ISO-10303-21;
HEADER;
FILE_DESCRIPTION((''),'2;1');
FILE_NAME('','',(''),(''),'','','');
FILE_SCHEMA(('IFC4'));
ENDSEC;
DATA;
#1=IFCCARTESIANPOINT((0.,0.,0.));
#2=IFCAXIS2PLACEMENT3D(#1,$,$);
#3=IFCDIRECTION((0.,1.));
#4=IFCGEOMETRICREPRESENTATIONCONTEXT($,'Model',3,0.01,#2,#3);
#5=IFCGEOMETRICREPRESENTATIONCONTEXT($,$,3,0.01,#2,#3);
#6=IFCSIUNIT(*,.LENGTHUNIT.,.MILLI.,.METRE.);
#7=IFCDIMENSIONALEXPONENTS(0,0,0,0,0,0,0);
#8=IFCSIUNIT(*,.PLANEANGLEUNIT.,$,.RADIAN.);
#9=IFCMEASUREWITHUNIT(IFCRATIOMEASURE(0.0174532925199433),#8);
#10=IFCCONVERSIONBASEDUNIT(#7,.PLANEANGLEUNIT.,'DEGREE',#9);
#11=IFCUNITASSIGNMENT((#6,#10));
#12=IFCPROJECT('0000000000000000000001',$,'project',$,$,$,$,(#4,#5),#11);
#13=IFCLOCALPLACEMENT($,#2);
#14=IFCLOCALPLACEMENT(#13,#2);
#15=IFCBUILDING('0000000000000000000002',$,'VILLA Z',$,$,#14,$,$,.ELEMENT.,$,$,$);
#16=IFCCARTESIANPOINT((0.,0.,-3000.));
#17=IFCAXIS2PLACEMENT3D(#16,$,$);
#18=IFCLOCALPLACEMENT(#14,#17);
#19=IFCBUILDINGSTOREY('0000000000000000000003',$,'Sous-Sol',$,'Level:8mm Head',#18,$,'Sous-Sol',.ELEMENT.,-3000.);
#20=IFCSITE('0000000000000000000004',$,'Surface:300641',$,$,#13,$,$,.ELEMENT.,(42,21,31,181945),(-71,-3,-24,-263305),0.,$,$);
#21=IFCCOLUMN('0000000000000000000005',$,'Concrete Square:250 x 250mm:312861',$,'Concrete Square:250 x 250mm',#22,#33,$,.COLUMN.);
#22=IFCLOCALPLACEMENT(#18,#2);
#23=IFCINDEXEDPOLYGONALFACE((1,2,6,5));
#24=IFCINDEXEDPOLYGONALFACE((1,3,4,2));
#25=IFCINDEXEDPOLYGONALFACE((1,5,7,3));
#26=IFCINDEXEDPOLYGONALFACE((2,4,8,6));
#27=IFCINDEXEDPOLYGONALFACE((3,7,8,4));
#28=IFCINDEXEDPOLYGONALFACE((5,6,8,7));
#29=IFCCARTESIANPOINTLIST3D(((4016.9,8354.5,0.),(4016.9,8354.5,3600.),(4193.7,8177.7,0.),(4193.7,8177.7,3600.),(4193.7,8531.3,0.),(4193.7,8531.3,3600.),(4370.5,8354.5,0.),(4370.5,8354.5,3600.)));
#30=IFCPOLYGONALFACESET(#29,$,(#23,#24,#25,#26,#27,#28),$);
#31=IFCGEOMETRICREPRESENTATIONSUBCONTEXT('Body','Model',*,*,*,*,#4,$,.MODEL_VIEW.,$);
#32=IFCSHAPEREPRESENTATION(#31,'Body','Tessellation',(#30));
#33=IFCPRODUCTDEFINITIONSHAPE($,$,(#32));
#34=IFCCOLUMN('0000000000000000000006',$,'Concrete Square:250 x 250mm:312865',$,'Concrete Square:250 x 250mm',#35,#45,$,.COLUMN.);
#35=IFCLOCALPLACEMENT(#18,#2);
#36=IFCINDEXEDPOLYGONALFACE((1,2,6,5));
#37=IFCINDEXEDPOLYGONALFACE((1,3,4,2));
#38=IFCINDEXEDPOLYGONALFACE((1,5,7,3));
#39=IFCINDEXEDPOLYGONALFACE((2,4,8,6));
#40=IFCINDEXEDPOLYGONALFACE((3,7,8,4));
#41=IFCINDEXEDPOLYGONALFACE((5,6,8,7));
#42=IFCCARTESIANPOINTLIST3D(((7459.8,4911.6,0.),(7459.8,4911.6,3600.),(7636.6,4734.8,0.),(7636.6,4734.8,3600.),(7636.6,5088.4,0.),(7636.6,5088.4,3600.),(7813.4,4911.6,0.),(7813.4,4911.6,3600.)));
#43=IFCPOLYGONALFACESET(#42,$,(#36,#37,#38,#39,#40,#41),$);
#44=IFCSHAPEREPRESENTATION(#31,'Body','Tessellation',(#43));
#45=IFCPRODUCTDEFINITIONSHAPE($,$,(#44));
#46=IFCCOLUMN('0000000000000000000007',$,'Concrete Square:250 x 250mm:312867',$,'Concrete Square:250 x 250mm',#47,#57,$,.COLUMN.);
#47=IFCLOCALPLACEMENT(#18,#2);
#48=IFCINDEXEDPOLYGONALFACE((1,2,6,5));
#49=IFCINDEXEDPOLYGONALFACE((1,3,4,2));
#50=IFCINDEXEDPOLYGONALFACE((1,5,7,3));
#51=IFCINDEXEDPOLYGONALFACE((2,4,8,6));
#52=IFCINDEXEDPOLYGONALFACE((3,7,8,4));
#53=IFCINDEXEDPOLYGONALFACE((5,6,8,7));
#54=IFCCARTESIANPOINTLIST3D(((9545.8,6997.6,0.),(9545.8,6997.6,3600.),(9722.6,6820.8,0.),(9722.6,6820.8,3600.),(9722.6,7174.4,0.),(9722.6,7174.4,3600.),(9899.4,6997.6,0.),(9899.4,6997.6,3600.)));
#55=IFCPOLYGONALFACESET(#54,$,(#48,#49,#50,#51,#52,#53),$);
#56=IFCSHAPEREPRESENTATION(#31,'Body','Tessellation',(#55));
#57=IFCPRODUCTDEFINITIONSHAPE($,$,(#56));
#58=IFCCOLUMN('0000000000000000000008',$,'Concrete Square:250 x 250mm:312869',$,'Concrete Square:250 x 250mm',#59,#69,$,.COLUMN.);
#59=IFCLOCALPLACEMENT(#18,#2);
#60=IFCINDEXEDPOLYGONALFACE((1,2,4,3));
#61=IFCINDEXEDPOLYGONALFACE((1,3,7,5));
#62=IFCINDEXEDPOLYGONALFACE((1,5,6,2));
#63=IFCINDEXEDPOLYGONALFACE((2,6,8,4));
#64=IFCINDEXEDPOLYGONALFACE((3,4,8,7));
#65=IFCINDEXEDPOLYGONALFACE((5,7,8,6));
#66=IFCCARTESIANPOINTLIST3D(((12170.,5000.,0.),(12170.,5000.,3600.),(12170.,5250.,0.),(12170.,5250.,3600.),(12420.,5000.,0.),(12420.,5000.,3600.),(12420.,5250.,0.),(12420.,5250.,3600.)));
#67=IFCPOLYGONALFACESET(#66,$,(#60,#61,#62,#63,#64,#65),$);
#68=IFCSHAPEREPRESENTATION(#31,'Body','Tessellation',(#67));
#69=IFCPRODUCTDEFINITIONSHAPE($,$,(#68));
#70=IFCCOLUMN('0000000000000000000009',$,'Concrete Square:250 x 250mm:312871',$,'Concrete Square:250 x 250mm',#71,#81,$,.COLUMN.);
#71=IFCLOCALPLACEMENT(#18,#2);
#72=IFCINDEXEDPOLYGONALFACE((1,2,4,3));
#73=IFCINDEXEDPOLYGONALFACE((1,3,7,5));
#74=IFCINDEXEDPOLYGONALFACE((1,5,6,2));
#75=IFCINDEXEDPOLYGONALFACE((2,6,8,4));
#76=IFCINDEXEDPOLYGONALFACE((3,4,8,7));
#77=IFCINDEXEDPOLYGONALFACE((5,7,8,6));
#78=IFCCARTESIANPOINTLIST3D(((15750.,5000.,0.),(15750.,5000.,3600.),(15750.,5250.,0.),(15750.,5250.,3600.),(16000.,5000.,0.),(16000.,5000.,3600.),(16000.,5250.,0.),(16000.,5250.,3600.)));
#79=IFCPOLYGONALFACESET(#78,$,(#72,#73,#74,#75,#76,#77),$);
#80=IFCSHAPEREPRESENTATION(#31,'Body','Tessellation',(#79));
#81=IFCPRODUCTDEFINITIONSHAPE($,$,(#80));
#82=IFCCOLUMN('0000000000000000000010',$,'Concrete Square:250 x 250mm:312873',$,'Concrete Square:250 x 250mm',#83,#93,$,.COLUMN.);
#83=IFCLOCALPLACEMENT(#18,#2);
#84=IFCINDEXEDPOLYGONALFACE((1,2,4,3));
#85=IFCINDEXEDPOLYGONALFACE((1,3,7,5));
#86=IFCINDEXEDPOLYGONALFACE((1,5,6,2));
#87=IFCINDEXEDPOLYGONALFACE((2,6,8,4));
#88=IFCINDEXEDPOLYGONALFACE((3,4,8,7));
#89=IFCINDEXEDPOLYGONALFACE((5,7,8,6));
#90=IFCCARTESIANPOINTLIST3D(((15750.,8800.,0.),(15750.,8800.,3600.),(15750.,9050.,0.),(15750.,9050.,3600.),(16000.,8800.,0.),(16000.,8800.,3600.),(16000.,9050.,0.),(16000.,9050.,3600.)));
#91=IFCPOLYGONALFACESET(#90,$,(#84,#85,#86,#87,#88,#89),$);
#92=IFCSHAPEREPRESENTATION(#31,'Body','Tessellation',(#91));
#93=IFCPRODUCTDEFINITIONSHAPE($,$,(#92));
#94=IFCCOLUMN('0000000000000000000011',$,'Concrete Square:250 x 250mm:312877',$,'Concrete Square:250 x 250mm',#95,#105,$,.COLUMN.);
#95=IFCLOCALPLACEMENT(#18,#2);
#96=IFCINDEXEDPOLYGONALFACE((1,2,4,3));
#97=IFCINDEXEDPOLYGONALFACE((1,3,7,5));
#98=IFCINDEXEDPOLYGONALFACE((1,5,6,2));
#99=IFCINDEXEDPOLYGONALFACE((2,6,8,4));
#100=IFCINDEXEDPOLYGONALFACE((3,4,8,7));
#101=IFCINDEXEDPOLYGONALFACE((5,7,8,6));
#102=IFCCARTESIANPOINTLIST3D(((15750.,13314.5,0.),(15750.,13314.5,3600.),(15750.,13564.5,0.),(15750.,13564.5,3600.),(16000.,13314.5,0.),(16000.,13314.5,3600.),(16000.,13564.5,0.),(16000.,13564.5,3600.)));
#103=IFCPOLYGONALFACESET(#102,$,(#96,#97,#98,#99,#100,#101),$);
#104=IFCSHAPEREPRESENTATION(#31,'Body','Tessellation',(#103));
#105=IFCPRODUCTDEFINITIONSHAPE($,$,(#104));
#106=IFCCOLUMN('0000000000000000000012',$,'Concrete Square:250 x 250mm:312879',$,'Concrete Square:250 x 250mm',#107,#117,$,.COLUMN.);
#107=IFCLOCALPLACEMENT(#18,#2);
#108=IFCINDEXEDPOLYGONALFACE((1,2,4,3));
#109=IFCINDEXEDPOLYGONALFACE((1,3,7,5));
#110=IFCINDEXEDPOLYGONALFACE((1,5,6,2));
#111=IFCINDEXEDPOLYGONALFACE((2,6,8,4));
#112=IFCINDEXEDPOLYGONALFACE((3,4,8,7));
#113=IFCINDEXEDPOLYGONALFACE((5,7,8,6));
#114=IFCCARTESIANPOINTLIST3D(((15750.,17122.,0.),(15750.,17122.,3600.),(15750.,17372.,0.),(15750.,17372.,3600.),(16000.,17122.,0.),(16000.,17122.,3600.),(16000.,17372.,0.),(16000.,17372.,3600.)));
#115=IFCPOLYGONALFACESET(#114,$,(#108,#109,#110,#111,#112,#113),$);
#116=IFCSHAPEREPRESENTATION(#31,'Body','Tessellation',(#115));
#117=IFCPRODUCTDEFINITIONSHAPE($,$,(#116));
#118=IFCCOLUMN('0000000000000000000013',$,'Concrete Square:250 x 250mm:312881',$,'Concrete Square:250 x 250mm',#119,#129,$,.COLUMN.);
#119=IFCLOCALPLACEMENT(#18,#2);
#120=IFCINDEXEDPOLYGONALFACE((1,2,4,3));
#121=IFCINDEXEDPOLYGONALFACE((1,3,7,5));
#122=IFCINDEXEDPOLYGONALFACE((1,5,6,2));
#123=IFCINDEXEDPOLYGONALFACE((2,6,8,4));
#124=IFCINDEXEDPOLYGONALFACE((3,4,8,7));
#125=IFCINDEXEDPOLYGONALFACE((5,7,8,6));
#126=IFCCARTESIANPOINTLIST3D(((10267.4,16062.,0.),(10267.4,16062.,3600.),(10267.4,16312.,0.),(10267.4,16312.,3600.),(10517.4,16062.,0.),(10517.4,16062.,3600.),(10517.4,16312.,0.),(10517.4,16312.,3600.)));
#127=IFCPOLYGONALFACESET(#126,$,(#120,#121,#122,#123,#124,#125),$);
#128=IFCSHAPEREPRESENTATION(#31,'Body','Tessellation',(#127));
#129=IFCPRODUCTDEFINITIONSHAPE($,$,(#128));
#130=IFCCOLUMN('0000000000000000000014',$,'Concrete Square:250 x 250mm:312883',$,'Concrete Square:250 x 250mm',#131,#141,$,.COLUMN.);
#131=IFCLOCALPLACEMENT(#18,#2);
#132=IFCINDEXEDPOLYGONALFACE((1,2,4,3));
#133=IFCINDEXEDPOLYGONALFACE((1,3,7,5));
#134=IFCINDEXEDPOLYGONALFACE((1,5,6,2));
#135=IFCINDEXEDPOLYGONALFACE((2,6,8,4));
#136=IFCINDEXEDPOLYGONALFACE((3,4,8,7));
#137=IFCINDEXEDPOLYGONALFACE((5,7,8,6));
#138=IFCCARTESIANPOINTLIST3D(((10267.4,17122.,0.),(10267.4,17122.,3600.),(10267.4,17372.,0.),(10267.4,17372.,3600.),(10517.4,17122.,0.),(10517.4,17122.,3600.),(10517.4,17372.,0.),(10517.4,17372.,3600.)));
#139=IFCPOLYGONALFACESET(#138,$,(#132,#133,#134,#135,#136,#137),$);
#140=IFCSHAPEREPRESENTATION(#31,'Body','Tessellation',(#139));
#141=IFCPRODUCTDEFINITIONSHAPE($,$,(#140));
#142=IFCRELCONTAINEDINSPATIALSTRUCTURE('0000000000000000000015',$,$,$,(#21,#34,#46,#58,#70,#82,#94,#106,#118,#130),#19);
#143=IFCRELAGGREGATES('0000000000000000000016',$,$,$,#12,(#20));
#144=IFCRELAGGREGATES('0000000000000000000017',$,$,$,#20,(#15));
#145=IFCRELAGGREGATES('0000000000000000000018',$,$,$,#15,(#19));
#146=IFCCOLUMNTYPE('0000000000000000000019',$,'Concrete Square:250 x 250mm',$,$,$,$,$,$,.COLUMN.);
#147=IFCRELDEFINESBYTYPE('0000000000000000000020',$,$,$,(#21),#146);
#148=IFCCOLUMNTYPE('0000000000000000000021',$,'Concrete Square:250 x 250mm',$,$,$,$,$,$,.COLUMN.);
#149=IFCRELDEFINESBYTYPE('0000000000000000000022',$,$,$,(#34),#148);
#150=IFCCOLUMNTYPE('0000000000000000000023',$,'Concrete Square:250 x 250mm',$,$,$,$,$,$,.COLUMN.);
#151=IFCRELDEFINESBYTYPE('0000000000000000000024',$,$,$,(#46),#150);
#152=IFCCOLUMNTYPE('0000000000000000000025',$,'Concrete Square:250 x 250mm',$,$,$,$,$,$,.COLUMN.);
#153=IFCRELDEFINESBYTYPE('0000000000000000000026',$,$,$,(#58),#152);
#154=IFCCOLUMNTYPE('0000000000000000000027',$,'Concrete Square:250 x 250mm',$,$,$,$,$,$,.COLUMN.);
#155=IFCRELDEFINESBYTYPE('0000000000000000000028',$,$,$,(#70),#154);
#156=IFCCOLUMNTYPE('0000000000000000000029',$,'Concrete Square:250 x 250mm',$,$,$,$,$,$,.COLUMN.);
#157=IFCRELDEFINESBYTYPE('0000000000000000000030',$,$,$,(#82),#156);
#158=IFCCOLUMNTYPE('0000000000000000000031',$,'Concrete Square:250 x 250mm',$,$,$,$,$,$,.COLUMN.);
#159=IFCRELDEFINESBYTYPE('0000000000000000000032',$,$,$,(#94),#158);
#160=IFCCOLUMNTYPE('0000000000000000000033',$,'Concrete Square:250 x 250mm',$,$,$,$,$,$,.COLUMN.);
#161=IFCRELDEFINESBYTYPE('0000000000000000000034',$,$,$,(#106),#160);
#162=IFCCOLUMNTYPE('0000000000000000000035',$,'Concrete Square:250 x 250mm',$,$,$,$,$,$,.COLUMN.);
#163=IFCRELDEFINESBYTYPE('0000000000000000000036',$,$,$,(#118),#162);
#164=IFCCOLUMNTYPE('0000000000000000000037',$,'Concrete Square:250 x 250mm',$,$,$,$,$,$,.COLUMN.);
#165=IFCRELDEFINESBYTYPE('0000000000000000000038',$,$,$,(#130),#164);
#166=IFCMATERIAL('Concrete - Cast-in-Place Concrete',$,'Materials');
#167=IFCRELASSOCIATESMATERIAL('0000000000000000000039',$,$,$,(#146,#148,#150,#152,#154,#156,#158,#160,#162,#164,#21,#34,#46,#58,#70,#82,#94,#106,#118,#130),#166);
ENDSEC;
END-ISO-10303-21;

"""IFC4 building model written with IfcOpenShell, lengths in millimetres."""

from ifc_helpers import new_model, entity, si_unit, converted_unit, direction, frame, frame_2d, origin, origin_2d_with_axis, place, context, subcontext, project, spatial, rectangle, extrude, source, transform, mapped, material, material_profile, profile_set, profile_usage, type_object, type_shapes, element, save


model = new_model("IFC4")

# Units and contexts
model_context = context("Model", 3, precision=0.01, world=origin(), true_north=direction((0.0, 1.0)))
context_of_model = context(None, 3, precision=0.01, world=origin(), true_north=direction((0.0, 1.0)))
body_context = subcontext(model_context, "Body", "Model", "MODEL_VIEW")
ifc_project = project(units=[si_unit("LENGTHUNIT", "METRE", prefix="MILLI"), converted_unit("PLANEANGLEUNIT", "DEGREE", entity("IfcRatioMeasure", 0.0174532925199433), si_unit("PLANEANGLEUNIT", "RADIAN"), dimensions=[0, 0, 0, 0, 0, 0, 0])], contexts=[model_context, context_of_model])

# Site, building, storey
site_placement = place(None, origin())
site = spatial("IfcSite", under=ifc_project, at=site_placement, Name="Surface:300641", CompositionType="ELEMENT", RefLatitude=(42, 21, 31, 181945), RefLongitude=(-71, -3, -24, -263305), RefElevation=0.0)
building_placement = place(site_placement, origin())
building = spatial("IfcBuilding", under=site, at=building_placement, Name="VILLA Z", CompositionType="ELEMENT")
storey_placement = place(building_placement, frame((0.0, 0.0, -3000.0)))
storey = spatial("IfcBuildingStorey", under=building, at=storey_placement, Name="Sous-Sol", ObjectType="Level:8mm Head", LongName="Sous-Sol", CompositionType="ELEMENT", Elevation=-3000.0)

# Columns
ifc_material_1 = material(Name="Concrete - Cast-in-Place Concrete", Category="Materials")
ifc_material_profile = material_profile(ifc_material_1, rectangle(XDim=250.0, YDim=250.0, at=frame_2d((0.0, 0.0), x_axis=(1.0, 0.0))), Name="250 x 250mm")
ifc_profile_set = profile_set([ifc_material_profile], Name="250 x 250mm")
ifc_profile_usage_1 = profile_usage(ifc_profile_set)
column_type_1 = type_object("IfcColumnType", Name="Concrete Square:250 x 250mm", PredefinedType="COLUMN", material=ifc_profile_set)
shared_shape_1 = source(origin(), body_context, "Body", "SweptSolid", [
    extrude(rectangle(XDim=250.0, YDim=250.0, at=frame_2d((0.0, 0.0), x_axis=(1.0, 0.0))), frame((4193.7, 8354.5, -3000.0), z_axis=(0.0, 0.0, 1.0), x_axis=(-0.707107, 0.707107, 0.0)), (0.0, 0.0, 1.0), 3600.0),
])
type_shapes(column_type_1, [shared_shape_1])
column_1_placement = place(storey_placement, frame((0.0, 0.0, 3000.0)))
element("IfcColumn", 1, at=column_1_placement, inside=storey, type_object=column_type_1, material=ifc_profile_usage_1, Name="Concrete Square:250 x 250mm:312861", ObjectType="Concrete Square:250 x 250mm", PredefinedType="COLUMN", context=body_context, shape_type="MappedRepresentation", body=[
    mapped(shared_shape_1, transform((0.0, 0.0, 0.0), scale=1.0)),
])
ifc_profile_usage_2 = profile_usage(ifc_profile_set)
column_type_2 = type_object("IfcColumnType", Name="Concrete Square:250 x 250mm", PredefinedType="COLUMN", material=ifc_profile_set)
shared_shape_2 = source(origin(), body_context, "Body", "SweptSolid", [
    extrude(rectangle(XDim=250.0, YDim=250.0, at=frame_2d((0.0, 0.0), x_axis=(1.0, 0.0))), frame((7636.6, 4911.6, -3000.0), z_axis=(0.0, 0.0, 1.0), x_axis=(-0.707107, 0.707107, 0.0)), (0.0, 0.0, 1.0), 3600.0),
])
type_shapes(column_type_2, [shared_shape_2])
column_2_placement = place(storey_placement, frame((0.0, 0.0, 3000.0)))
element("IfcColumn", 2, at=column_2_placement, inside=storey, type_object=column_type_2, material=ifc_profile_usage_2, Name="Concrete Square:250 x 250mm:312865", ObjectType="Concrete Square:250 x 250mm", PredefinedType="COLUMN", context=body_context, shape_type="MappedRepresentation", body=[
    mapped(shared_shape_2, transform((0.0, 0.0, 0.0), scale=1.0)),
])
ifc_profile_usage_3 = profile_usage(ifc_profile_set)
column_type_3 = type_object("IfcColumnType", Name="Concrete Square:250 x 250mm", PredefinedType="COLUMN", material=ifc_profile_set)
shared_shape_3 = source(origin(), body_context, "Body", "SweptSolid", [
    extrude(rectangle(XDim=250.0, YDim=250.0, at=origin_2d_with_axis()), frame((9722.6, 6997.6, -3000.0), z_axis=(0.0, 0.0, 1.0), x_axis=(-0.707107, 0.707107, 0.0)), (0.0, 0.0, 1.0), 3600.0),
])
type_shapes(column_type_3, [shared_shape_3])
column_3_placement = place(storey_placement, frame((0.0, 0.0, 3000.0)))
element("IfcColumn", 3, at=column_3_placement, inside=storey, type_object=column_type_3, material=ifc_profile_usage_3, Name="Concrete Square:250 x 250mm:312867", ObjectType="Concrete Square:250 x 250mm", PredefinedType="COLUMN", context=body_context, shape_type="MappedRepresentation", body=[
    mapped(shared_shape_3, transform((0.0, 0.0, 0.0), scale=1.0)),
])
ifc_profile_usage_4 = profile_usage(ifc_profile_set)
column_type_4 = type_object("IfcColumnType", Name="Concrete Square:250 x 250mm", PredefinedType="COLUMN", material=ifc_profile_set)
shared_shape_4 = source(origin(), body_context, "Body", "SweptSolid", [
    extrude(rectangle(XDim=250.0, YDim=250.0, at=origin_2d_with_axis()), frame((12295.0, 5125.0, -3000.0), z_axis=(0.0, 0.0, 1.0), x_axis=(0.0, -1.0, 0.0)), (0.0, 0.0, 1.0), 3600.0),
])
type_shapes(column_type_4, [shared_shape_4])
column_4_placement = place(storey_placement, frame((0.0, 0.0, 3000.0)))
element("IfcColumn", 4, at=column_4_placement, inside=storey, type_object=column_type_4, material=ifc_profile_usage_4, Name="Concrete Square:250 x 250mm:312869", ObjectType="Concrete Square:250 x 250mm", PredefinedType="COLUMN", context=body_context, shape_type="MappedRepresentation", body=[
    mapped(shared_shape_4, transform((0.0, 0.0, 0.0), scale=1.0)),
])
ifc_profile_usage_5 = profile_usage(ifc_profile_set)
column_type_5 = type_object("IfcColumnType", Name="Concrete Square:250 x 250mm", PredefinedType="COLUMN", material=ifc_profile_set)
shared_shape_5 = source(origin(), body_context, "Body", "SweptSolid", [
    extrude(rectangle(XDim=250.0, YDim=250.0, at=origin_2d_with_axis()), frame((15875.0, 5125.0, -3000.0), z_axis=(0.0, 0.0, 1.0), x_axis=(0.0, -1.0, 0.0)), (0.0, 0.0, 1.0), 3600.0),
])
type_shapes(column_type_5, [shared_shape_5])
column_5_placement = place(storey_placement, frame((0.0, 0.0, 3000.0)))
element("IfcColumn", 5, at=column_5_placement, inside=storey, type_object=column_type_5, material=ifc_profile_usage_5, Name="Concrete Square:250 x 250mm:312871", ObjectType="Concrete Square:250 x 250mm", PredefinedType="COLUMN", context=body_context, shape_type="MappedRepresentation", body=[
    mapped(shared_shape_5, transform((0.0, 0.0, 0.0), scale=1.0)),
])
ifc_profile_usage_6 = profile_usage(ifc_profile_set)
column_type_6 = type_object("IfcColumnType", Name="Concrete Square:250 x 250mm", PredefinedType="COLUMN", material=ifc_profile_set)
shared_shape_6 = source(origin(), body_context, "Body", "SweptSolid", [
    extrude(rectangle(XDim=250.0, YDim=250.0, at=origin_2d_with_axis()), frame((15875.0, 8925.0, -3000.0), z_axis=(0.0, 0.0, 1.0), x_axis=(0.0, -1.0, 0.0)), (0.0, 0.0, 1.0), 3600.0),
])
type_shapes(column_type_6, [shared_shape_6])
column_6_placement = place(storey_placement, frame((0.0, 0.0, 3000.0)))
element("IfcColumn", 6, at=column_6_placement, inside=storey, type_object=column_type_6, material=ifc_profile_usage_6, Name="Concrete Square:250 x 250mm:312873", ObjectType="Concrete Square:250 x 250mm", PredefinedType="COLUMN", context=body_context, shape_type="MappedRepresentation", body=[
    mapped(shared_shape_6, transform((0.0, 0.0, 0.0), scale=1.0)),
])
ifc_profile_usage_7 = profile_usage(ifc_profile_set)
column_type_7 = type_object("IfcColumnType", Name="Concrete Square:250 x 250mm", PredefinedType="COLUMN", material=ifc_profile_set)
shared_shape_7 = source(origin(), body_context, "Body", "SweptSolid", [
    extrude(rectangle(XDim=250.0, YDim=250.0, at=frame_2d((0.0, 0.0), x_axis=(1.0, 0.0))), frame((15875.0, 13439.5, -3000.0), z_axis=(0.0, 0.0, 1.0), x_axis=(0.0, -1.0, 0.0)), (0.0, 0.0, 1.0), 3600.0),
])
type_shapes(column_type_7, [shared_shape_7])
column_7_placement = place(storey_placement, frame((0.0, 0.0, 3000.0)))
element("IfcColumn", 7, at=column_7_placement, inside=storey, type_object=column_type_7, material=ifc_profile_usage_7, Name="Concrete Square:250 x 250mm:312877", ObjectType="Concrete Square:250 x 250mm", PredefinedType="COLUMN", context=body_context, shape_type="MappedRepresentation", body=[
    mapped(shared_shape_7, transform((0.0, 0.0, 0.0), scale=1.0)),
])
ifc_profile_usage_8 = profile_usage(ifc_profile_set)
column_type_8 = type_object("IfcColumnType", Name="Concrete Square:250 x 250mm", PredefinedType="COLUMN", material=ifc_profile_set)
shared_shape_8 = source(origin(), body_context, "Body", "SweptSolid", [
    extrude(rectangle(XDim=250.0, YDim=250.0, at=origin_2d_with_axis()), frame((15875.0, 17247.0, -3000.0), z_axis=(0.0, 0.0, 1.0), x_axis=(0.0, -1.0, 0.0)), (0.0, 0.0, 1.0), 3600.0),
])
type_shapes(column_type_8, [shared_shape_8])
column_8_placement = place(storey_placement, frame((0.0, 0.0, 3000.0)))
element("IfcColumn", 8, at=column_8_placement, inside=storey, type_object=column_type_8, material=ifc_profile_usage_8, Name="Concrete Square:250 x 250mm:312879", ObjectType="Concrete Square:250 x 250mm", PredefinedType="COLUMN", context=body_context, shape_type="MappedRepresentation", body=[
    mapped(shared_shape_8, transform((0.0, 0.0, 0.0), scale=1.0)),
])
ifc_profile_usage_9 = profile_usage(ifc_profile_set)
column_type_9 = type_object("IfcColumnType", Name="Concrete Square:250 x 250mm", PredefinedType="COLUMN", material=ifc_profile_set)
shared_shape_9 = source(origin(), body_context, "Body", "SweptSolid", [
    extrude(rectangle(XDim=250.0, YDim=250.0, at=frame_2d((0.0, 0.0), x_axis=(1.0, 0.0))), frame((10392.4, 16187.0, -3000.0), z_axis=(0.0, 0.0, 1.0), x_axis=(0.0, -1.0, 0.0)), (0.0, 0.0, 1.0), 3600.0),
])
type_shapes(column_type_9, [shared_shape_9])
column_9_placement = place(storey_placement, frame((0.0, 0.0, 3000.0)))
element("IfcColumn", 9, at=column_9_placement, inside=storey, type_object=column_type_9, material=ifc_profile_usage_9, Name="Concrete Square:250 x 250mm:312881", ObjectType="Concrete Square:250 x 250mm", PredefinedType="COLUMN", context=body_context, shape_type="MappedRepresentation", body=[
    mapped(shared_shape_9, transform((0.0, 0.0, 0.0), scale=1.0)),
])
ifc_profile_usage_10 = profile_usage(ifc_profile_set)
column_type_10 = type_object("IfcColumnType", Name="Concrete Square:250 x 250mm", PredefinedType="COLUMN", material=ifc_profile_set)
shared_shape_10 = source(origin(), body_context, "Body", "SweptSolid", [
    extrude(rectangle(XDim=250.0, YDim=250.0, at=origin_2d_with_axis()), frame((10392.4, 17247.0, -3000.0), z_axis=(0.0, 0.0, 1.0), x_axis=(0.0, -1.0, 0.0)), (0.0, 0.0, 1.0), 3600.0),
])
type_shapes(column_type_10, [shared_shape_10])
column_10_placement = place(storey_placement, frame((0.0, 0.0, 3000.0)))
element("IfcColumn", 10, at=column_10_placement, inside=storey, type_object=column_type_10, material=ifc_profile_usage_10, Name="Concrete Square:250 x 250mm:312883", ObjectType="Concrete Square:250 x 250mm", PredefinedType="COLUMN", context=body_context, shape_type="MappedRepresentation", body=[
    mapped(shared_shape_10, transform((0.0, 0.0, 0.0), scale=1.0)),
])

save(model, "model.ifc")
